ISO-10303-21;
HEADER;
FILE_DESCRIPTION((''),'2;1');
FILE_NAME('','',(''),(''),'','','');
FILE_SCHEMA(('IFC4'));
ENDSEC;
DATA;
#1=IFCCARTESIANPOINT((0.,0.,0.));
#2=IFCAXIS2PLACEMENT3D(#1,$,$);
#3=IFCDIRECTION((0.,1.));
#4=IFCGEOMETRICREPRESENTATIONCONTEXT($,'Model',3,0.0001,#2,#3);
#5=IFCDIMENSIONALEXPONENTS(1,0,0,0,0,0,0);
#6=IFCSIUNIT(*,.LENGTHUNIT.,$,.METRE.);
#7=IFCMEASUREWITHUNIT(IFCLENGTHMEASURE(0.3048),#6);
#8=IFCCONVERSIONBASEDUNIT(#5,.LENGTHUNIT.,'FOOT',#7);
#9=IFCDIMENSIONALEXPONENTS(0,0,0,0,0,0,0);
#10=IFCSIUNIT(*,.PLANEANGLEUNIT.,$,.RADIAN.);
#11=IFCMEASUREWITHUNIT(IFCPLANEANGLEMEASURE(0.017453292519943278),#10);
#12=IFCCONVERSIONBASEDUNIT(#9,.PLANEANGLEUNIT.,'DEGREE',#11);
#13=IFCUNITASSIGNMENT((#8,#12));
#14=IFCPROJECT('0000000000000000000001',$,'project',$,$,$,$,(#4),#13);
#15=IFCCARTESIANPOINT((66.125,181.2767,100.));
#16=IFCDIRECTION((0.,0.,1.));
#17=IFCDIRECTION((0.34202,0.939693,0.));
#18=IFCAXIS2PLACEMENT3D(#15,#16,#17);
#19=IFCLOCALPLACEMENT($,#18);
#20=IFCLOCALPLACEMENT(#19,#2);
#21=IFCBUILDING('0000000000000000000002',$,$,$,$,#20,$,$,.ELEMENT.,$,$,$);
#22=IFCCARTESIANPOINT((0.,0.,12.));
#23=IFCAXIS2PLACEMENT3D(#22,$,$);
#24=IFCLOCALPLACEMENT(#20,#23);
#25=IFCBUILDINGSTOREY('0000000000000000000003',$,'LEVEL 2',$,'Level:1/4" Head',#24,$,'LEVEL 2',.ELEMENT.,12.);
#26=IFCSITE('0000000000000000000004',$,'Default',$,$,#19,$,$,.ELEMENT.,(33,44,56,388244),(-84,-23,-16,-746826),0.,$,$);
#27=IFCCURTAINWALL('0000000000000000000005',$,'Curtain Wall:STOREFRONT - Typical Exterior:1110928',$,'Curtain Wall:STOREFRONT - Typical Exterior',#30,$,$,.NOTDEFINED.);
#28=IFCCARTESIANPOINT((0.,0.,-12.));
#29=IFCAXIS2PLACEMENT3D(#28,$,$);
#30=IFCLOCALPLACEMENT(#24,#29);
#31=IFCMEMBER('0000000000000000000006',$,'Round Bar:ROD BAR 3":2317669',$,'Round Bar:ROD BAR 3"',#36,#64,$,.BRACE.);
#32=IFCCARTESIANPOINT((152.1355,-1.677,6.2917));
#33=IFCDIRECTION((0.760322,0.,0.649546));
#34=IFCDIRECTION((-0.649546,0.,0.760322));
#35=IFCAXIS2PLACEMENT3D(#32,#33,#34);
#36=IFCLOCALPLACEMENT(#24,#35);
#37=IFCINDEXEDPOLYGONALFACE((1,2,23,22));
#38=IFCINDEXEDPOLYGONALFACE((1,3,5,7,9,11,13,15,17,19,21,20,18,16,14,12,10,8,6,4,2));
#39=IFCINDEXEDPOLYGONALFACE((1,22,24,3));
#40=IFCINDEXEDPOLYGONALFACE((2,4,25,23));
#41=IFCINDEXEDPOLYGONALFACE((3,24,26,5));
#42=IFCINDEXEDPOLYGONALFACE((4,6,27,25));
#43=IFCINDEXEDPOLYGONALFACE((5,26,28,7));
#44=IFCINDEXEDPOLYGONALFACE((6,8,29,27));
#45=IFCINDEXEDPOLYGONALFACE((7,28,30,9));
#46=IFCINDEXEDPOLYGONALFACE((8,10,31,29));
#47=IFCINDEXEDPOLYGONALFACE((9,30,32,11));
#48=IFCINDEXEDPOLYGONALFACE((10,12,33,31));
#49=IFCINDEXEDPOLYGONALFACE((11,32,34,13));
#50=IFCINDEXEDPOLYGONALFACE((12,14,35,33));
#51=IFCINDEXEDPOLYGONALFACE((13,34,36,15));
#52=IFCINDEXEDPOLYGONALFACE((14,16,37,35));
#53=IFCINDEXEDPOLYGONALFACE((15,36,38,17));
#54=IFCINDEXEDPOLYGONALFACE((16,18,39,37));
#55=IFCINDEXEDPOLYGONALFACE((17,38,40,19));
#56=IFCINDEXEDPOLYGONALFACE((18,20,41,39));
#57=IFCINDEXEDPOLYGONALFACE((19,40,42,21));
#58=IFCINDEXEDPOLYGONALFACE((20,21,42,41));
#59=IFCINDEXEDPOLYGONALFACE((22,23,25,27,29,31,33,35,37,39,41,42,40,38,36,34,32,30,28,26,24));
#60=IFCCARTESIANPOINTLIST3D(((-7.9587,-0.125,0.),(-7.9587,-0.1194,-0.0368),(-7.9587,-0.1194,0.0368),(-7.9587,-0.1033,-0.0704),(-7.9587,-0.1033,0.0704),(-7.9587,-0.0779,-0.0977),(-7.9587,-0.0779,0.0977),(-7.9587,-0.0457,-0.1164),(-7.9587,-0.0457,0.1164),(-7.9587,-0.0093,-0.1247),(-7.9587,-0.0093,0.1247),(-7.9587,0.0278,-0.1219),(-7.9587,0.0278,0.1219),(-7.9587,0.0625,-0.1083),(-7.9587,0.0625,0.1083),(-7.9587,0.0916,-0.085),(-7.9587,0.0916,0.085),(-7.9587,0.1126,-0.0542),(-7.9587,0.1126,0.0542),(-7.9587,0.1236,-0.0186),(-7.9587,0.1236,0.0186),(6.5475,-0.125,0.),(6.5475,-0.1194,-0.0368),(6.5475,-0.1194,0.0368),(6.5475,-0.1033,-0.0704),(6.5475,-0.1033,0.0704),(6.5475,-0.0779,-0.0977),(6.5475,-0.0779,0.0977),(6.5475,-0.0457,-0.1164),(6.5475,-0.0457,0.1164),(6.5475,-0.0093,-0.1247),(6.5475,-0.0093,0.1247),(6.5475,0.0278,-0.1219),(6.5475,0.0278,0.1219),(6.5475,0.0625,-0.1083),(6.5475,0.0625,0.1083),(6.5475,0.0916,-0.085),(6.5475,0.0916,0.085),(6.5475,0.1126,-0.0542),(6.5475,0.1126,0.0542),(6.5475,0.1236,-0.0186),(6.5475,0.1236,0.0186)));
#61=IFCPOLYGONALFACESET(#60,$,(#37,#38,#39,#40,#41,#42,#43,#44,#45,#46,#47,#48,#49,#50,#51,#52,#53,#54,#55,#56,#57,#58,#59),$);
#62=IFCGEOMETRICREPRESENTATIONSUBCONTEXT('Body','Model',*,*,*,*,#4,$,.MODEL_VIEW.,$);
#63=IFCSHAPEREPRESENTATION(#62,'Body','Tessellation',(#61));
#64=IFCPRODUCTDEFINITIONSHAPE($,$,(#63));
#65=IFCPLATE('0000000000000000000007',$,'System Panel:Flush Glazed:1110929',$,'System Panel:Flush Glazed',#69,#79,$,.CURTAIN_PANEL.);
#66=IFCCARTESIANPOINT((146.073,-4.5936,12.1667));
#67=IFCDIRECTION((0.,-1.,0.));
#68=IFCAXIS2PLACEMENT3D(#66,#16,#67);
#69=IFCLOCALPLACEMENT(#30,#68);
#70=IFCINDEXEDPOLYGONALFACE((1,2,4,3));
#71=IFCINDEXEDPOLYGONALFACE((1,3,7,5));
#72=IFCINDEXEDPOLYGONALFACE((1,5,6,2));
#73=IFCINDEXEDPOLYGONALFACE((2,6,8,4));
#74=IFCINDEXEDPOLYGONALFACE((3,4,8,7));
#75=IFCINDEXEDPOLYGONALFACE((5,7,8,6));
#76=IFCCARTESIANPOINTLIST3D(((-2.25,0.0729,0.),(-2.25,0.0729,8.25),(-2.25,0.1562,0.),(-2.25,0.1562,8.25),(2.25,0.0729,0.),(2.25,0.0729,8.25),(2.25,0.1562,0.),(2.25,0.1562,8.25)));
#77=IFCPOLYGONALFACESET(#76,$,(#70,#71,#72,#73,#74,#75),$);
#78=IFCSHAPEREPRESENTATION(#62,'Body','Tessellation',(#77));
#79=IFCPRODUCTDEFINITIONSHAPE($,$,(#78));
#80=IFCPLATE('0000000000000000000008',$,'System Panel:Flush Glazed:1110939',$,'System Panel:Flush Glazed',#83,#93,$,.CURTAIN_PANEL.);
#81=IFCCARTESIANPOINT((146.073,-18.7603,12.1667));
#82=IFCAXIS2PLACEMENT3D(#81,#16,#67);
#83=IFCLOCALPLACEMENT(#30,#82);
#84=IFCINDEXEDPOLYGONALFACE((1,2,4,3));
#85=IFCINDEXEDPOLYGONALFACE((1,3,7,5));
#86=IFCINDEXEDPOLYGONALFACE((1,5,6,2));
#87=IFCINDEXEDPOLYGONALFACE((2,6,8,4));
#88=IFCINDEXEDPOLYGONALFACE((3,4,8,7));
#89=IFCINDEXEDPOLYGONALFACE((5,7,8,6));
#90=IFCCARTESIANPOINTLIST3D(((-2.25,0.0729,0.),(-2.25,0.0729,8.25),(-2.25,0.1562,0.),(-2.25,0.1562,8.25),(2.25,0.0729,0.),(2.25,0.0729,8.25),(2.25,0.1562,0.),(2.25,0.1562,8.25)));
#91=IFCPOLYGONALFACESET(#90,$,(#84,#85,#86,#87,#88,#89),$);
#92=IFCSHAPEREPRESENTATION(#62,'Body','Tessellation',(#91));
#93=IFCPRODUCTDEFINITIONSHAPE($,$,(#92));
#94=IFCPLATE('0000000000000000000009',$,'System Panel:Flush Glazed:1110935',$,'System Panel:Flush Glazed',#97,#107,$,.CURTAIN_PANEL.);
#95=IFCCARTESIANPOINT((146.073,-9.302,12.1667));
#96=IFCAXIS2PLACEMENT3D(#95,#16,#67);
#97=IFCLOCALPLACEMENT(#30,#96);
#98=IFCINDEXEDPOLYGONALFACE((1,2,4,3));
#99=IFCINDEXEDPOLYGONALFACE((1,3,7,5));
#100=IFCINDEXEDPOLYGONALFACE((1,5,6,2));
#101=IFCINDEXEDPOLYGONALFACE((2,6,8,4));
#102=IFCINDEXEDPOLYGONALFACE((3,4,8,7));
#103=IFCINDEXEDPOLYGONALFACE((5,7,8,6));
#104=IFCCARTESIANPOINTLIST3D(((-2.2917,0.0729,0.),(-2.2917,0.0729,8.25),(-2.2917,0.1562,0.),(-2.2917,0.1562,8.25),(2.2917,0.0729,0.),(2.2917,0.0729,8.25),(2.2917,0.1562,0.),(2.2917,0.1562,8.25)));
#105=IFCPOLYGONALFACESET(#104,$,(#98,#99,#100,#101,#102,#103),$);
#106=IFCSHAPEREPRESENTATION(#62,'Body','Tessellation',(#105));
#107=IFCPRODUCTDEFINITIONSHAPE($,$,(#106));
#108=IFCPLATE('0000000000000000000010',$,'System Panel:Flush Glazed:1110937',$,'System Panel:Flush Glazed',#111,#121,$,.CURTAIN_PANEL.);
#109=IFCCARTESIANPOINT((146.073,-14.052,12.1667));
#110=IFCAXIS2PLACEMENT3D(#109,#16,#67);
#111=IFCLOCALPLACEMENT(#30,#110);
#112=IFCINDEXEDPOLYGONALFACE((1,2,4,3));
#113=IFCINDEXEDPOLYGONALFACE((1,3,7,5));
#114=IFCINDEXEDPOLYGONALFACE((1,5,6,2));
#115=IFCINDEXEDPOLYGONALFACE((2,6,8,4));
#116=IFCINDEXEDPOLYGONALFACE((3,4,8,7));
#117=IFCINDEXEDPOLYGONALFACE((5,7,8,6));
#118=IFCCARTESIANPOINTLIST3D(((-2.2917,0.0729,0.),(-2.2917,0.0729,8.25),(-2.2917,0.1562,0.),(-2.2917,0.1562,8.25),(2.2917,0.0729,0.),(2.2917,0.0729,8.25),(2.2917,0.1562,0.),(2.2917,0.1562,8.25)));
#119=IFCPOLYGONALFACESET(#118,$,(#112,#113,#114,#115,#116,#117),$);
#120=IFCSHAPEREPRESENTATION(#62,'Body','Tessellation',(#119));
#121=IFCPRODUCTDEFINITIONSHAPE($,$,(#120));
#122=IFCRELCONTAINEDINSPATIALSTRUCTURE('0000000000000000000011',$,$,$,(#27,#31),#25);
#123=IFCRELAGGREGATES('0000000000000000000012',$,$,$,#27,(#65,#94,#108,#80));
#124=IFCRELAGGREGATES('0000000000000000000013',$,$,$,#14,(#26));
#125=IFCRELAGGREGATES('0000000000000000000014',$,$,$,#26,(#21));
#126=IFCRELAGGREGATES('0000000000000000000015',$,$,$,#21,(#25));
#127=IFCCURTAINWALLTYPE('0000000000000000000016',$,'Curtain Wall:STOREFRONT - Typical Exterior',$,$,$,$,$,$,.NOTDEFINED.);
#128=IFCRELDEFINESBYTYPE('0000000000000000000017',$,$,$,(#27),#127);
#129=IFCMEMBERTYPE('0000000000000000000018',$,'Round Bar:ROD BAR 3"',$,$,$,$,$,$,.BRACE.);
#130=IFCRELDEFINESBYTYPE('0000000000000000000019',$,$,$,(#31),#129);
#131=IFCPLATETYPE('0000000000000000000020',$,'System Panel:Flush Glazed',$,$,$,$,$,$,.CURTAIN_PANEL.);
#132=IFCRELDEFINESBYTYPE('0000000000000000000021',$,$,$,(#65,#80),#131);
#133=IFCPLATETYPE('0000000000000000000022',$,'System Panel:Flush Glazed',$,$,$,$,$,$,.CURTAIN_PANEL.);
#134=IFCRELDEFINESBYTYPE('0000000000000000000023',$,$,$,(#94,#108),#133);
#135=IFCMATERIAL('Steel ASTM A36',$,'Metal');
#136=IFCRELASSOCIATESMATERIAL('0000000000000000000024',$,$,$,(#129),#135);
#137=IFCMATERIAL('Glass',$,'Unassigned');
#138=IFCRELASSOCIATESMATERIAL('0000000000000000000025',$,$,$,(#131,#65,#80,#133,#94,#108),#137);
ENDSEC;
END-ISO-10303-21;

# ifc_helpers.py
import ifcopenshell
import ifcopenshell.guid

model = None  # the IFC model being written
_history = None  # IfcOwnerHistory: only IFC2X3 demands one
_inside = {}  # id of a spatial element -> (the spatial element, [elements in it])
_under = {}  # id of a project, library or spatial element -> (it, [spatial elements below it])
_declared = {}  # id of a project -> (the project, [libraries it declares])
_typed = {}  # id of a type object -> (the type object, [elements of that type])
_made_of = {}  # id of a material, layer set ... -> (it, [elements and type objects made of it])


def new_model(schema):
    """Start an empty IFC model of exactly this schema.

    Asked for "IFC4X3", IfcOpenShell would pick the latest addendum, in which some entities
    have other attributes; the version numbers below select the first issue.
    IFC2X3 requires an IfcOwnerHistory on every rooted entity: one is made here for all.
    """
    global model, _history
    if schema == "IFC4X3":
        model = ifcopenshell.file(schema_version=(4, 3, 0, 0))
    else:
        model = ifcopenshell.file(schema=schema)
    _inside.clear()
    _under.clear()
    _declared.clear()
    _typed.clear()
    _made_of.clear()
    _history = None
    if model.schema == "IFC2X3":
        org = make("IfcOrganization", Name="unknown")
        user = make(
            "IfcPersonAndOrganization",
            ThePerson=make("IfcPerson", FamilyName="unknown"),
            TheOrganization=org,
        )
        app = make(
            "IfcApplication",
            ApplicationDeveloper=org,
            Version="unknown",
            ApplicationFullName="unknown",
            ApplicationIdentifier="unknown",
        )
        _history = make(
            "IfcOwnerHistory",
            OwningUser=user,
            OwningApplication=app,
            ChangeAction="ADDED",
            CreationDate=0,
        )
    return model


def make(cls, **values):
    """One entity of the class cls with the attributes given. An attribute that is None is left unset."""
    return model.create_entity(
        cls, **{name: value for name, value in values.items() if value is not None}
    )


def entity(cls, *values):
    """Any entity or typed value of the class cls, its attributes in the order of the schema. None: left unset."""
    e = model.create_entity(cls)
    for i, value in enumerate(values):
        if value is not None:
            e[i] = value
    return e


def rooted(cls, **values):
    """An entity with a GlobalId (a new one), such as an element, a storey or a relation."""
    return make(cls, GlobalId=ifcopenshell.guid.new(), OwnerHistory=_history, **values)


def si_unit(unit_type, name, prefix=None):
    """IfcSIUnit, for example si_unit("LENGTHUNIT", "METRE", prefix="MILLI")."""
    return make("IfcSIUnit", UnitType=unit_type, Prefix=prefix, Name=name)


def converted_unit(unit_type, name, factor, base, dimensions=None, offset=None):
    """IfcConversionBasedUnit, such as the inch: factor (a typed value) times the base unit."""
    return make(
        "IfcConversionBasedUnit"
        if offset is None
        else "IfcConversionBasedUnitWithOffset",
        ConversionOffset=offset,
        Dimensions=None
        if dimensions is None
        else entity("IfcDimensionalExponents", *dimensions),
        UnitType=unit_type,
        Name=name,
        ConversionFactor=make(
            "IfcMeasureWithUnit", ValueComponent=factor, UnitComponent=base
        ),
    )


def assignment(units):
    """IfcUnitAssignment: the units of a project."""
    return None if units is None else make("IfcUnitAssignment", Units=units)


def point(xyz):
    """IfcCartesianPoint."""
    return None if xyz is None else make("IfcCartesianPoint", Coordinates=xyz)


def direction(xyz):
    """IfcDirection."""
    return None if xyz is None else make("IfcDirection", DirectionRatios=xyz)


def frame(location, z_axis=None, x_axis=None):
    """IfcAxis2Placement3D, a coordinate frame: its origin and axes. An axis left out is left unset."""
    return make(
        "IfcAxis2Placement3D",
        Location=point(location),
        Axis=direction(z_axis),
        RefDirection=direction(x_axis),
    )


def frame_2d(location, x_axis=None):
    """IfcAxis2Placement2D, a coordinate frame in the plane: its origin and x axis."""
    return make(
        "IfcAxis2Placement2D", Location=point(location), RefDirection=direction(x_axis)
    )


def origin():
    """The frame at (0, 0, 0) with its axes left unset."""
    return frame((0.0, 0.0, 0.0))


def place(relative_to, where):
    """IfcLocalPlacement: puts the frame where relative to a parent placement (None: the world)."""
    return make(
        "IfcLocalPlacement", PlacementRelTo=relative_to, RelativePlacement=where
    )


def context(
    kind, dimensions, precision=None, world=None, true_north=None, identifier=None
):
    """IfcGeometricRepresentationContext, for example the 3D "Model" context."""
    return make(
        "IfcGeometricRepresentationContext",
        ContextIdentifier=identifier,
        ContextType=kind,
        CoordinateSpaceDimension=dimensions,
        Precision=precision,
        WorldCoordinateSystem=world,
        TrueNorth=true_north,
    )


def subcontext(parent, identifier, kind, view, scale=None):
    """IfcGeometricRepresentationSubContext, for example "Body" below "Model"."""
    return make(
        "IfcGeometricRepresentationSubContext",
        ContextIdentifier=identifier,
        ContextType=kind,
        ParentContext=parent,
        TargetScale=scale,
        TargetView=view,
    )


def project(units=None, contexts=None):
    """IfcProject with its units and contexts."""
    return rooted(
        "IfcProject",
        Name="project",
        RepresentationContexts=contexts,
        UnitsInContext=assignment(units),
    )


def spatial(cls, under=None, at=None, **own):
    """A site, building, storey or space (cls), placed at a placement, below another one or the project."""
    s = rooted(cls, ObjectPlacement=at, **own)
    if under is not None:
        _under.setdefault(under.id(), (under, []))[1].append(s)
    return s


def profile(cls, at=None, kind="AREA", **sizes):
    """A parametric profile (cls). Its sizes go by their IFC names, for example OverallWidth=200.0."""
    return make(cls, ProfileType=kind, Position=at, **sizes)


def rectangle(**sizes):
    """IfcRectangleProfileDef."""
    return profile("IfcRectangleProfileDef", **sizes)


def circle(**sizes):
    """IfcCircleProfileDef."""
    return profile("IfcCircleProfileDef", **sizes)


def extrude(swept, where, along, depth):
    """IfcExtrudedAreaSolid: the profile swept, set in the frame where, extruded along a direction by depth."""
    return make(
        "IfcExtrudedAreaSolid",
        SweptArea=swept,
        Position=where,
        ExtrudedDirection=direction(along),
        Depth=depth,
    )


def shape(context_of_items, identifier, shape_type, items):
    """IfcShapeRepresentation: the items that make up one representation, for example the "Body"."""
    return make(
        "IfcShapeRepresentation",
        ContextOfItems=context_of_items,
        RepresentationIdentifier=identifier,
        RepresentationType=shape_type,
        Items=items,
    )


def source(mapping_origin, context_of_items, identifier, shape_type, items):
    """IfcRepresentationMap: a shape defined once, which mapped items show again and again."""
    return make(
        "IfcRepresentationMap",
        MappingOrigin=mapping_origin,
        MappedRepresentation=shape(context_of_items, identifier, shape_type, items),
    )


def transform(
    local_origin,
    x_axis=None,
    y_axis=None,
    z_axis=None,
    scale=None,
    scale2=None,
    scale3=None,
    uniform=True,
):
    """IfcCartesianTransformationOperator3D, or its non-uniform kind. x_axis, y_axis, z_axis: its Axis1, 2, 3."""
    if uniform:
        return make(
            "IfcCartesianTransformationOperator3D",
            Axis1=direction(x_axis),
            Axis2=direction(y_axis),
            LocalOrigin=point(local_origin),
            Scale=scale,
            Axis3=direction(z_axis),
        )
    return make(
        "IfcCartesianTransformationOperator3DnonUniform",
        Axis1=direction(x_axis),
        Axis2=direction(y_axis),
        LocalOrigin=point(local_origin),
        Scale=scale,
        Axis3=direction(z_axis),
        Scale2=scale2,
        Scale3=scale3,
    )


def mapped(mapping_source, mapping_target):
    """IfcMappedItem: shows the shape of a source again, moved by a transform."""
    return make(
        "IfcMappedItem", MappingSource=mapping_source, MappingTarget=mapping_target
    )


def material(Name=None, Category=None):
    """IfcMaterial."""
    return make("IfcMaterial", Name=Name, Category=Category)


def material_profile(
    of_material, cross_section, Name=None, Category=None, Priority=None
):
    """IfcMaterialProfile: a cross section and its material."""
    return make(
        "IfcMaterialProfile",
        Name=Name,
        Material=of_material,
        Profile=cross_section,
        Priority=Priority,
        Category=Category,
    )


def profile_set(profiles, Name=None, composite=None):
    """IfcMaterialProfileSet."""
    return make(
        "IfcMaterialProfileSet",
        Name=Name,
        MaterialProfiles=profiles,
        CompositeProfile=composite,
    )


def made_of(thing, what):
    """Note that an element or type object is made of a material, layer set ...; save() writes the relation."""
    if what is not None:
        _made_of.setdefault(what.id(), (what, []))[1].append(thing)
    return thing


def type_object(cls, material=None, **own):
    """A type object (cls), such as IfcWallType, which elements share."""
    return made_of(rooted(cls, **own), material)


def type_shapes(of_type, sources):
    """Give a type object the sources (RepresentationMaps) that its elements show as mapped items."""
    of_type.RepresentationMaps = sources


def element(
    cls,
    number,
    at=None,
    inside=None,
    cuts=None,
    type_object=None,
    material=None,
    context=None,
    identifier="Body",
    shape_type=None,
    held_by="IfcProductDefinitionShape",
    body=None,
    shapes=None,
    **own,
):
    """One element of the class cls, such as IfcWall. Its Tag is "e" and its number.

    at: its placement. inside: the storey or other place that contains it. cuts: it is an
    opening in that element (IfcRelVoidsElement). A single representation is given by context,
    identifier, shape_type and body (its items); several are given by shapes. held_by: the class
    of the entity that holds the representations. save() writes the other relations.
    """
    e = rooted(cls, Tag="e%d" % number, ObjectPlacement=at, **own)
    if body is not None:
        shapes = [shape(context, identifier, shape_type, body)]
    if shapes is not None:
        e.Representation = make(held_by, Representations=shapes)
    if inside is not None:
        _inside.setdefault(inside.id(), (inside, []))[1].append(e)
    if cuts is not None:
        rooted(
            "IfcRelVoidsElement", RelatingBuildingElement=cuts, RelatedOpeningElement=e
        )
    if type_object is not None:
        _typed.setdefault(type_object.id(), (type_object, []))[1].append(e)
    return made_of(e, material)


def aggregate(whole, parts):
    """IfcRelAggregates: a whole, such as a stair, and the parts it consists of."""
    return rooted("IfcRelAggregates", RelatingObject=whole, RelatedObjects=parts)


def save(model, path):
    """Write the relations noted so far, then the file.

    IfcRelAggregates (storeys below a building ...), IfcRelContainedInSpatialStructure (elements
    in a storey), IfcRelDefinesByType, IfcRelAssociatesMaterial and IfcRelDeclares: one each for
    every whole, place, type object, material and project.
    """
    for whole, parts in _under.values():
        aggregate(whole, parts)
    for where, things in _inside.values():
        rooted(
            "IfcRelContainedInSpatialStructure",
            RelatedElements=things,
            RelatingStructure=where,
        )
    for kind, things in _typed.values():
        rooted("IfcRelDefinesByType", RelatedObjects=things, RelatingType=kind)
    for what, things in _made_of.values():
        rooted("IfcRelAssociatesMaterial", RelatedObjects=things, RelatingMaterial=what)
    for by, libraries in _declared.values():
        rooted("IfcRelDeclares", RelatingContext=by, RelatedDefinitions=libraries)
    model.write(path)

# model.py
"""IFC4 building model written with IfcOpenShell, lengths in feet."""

from ifc_helpers import new_model, entity, si_unit, converted_unit, direction, frame, frame_2d, origin, place, context, subcontext, project, spatial, rectangle, circle, extrude, source, transform, mapped, material, material_profile, profile_set, type_object, type_shapes, element, aggregate, save


model = new_model("IFC4")

# Units and contexts
model_context = context("Model", 3, precision=0.0001, world=origin(), true_north=direction((0.0, 1.0)))
body_context = subcontext(model_context, "Body", "Model", "MODEL_VIEW")
ifc_project = project(units=[converted_unit("LENGTHUNIT", "FOOT", entity("IfcLengthMeasure", 0.3048), si_unit("LENGTHUNIT", "METRE"), dimensions=[1, 0, 0, 0, 0, 0, 0]), converted_unit("PLANEANGLEUNIT", "DEGREE", entity("IfcPlaneAngleMeasure", 0.017453292519943278), si_unit("PLANEANGLEUNIT", "RADIAN"), dimensions=[0, 0, 0, 0, 0, 0, 0])], contexts=[model_context])

# Site, building, storey
site_placement = place(None, frame((66.125, 181.2767, 100.0), z_axis=(0.0, 0.0, 1.0), x_axis=(0.34202, 0.939693, 0.0)))
site = spatial("IfcSite", under=ifc_project, at=site_placement, Name="Default", CompositionType="ELEMENT", RefLatitude=(33, 44, 56, 388244), RefLongitude=(-84, -23, -16, -746826), RefElevation=0.0)
building_placement = place(site_placement, origin())
building = spatial("IfcBuilding", under=site, at=building_placement, CompositionType="ELEMENT")
storey_placement = place(building_placement, frame((0.0, 0.0, 12.0)))
storey = spatial("IfcBuildingStorey", under=building, at=storey_placement, Name="LEVEL 2", ObjectType="Level:1/4\" Head", LongName="LEVEL 2", CompositionType="ELEMENT", Elevation=12.0)

# Curtain wall
curtain_wall_type = type_object("IfcCurtainWallType", Name="Curtain Wall:STOREFRONT - Typical Exterior", PredefinedType="NOTDEFINED")
curtain_wall_1_placement = place(storey_placement, frame((0.0, 0.0, -12.0)))
curtain_wall_1 = element("IfcCurtainWall", 1, at=curtain_wall_1_placement, inside=storey, type_object=curtain_wall_type, Name="Curtain Wall:STOREFRONT - Typical Exterior:1110928", ObjectType="Curtain Wall:STOREFRONT - Typical Exterior", PredefinedType="NOTDEFINED")

# Member
ifc_material_1 = material(Name="Steel ASTM A36", Category="Metal")
ifc_material_profile_1 = material_profile(ifc_material_1, circle(Radius=0.125, at=frame_2d((0.0, 0.0), x_axis=(1.0, 0.0))), Name="ROD BAR 3\"")
ifc_profile_set_1 = profile_set([ifc_material_profile_1], Name="ROD BAR 3\"")
member_type_1 = type_object("IfcMemberType", Name="Round Bar:ROD BAR 3\"", PredefinedType="BRACE", material=ifc_profile_set_1)
shared_shape_1 = source(origin(), body_context, "Body", "SweptSolid", [
    extrude(circle(Radius=0.125, at=frame_2d((0.0, 0.0), x_axis=(1.0, 0.0))), frame((-7.9587, 0.0, 0.0), z_axis=(1.0, 0.0, 0.0), x_axis=(0.0, -1.0, 0.0)), (0.0, 0.0, 1.0), 14.5062),
])
type_shapes(member_type_1, [shared_shape_1])
member_1_placement = place(storey_placement, frame((152.1355, -1.677, 6.2917), z_axis=(0.760322, 0.0, 0.649546), x_axis=(-0.649546, 0.0, 0.760322)))
element("IfcMember", 2, at=member_1_placement, inside=storey, type_object=member_type_1, Name="Round Bar:ROD BAR 3\":2317669", ObjectType="Round Bar:ROD BAR 3\"", PredefinedType="BRACE", context=body_context, shape_type="MappedRepresentation", body=[
    mapped(shared_shape_1, transform((0.0, 0.0, 0.0), scale=1.0)),
])

# Plates
ifc_material_2 = material(Name="Glass", Category="Unassigned")
plate_type_1 = type_object("IfcPlateType", Name="System Panel:Flush Glazed", PredefinedType="CURTAIN_PANEL", material=ifc_material_2)
shared_shape_2 = source(origin(), body_context, "Body", "SweptSolid", [
    extrude(rectangle(XDim=0.0833, YDim=4.5, at=frame_2d((0.0, 0.0), x_axis=(1.0, 0.0))), frame((0.0, 0.1146, 0.0), z_axis=(0.0, 0.0, 1.0), x_axis=(0.0, 1.0, 0.0)), (0.0, 0.0, 1.0), 8.25),
])
type_shapes(plate_type_1, [shared_shape_2])
plate_1_placement = place(curtain_wall_1_placement, frame((146.073, -4.5936, 12.1667), z_axis=(0.0, 0.0, 1.0), x_axis=(0.0, -1.0, 0.0)))
plate_1 = element("IfcPlate", 3, at=plate_1_placement, type_object=plate_type_1, material=ifc_material_2, Name="System Panel:Flush Glazed:1110929", ObjectType="System Panel:Flush Glazed", PredefinedType="CURTAIN_PANEL", context=body_context, shape_type="MappedRepresentation", body=[
    mapped(shared_shape_2, transform((0.0, 0.0, 0.0), scale=1.0)),
])
plate_2_placement = place(curtain_wall_1_placement, frame((146.073, -18.7603, 12.1667), z_axis=(0.0, 0.0, 1.0), x_axis=(0.0, -1.0, 0.0)))
plate_2 = element("IfcPlate", 4, at=plate_2_placement, type_object=plate_type_1, material=ifc_material_2, Name="System Panel:Flush Glazed:1110939", ObjectType="System Panel:Flush Glazed", PredefinedType="CURTAIN_PANEL", context=body_context, shape_type="MappedRepresentation", body=[
    mapped(shared_shape_2, transform((0.0, 0.0, 0.0), scale=1.0)),
])
plate_type_2 = type_object("IfcPlateType", Name="System Panel:Flush Glazed", PredefinedType="CURTAIN_PANEL", material=ifc_material_2)
shared_shape_3 = source(origin(), body_context, "Body", "SweptSolid", [
    extrude(rectangle(XDim=0.0833, YDim=4.5833, at=frame_2d((0.0, 0.0), x_axis=(1.0, 0.0))), frame((0.0, 0.1146, 0.0), z_axis=(0.0, 0.0, 1.0), x_axis=(0.0, 1.0, 0.0)), (0.0, 0.0, 1.0), 8.25),
])
type_shapes(plate_type_2, [shared_shape_3])
plate_3_placement = place(curtain_wall_1_placement, frame((146.073, -9.302, 12.1667), z_axis=(0.0, 0.0, 1.0), x_axis=(0.0, -1.0, 0.0)))
plate_3 = element("IfcPlate", 5, at=plate_3_placement, type_object=plate_type_2, material=ifc_material_2, Name="System Panel:Flush Glazed:1110935", ObjectType="System Panel:Flush Glazed", PredefinedType="CURTAIN_PANEL", context=body_context, shape_type="MappedRepresentation", body=[
    mapped(shared_shape_3, transform((0.0, 0.0, 0.0), scale=1.0)),
])
plate_4_placement = place(curtain_wall_1_placement, frame((146.073, -14.052, 12.1667), z_axis=(0.0, 0.0, 1.0), x_axis=(0.0, -1.0, 0.0)))
plate_4 = element("IfcPlate", 6, at=plate_4_placement, type_object=plate_type_2, material=ifc_material_2, Name="System Panel:Flush Glazed:1110937", ObjectType="System Panel:Flush Glazed", PredefinedType="CURTAIN_PANEL", context=body_context, shape_type="MappedRepresentation", body=[
    mapped(shared_shape_3, transform((0.0, 0.0, 0.0), scale=1.0)),
])
aggregate(curtain_wall_1, [plate_1, plate_3, plate_4, plate_2])

save(model, "model.ifc")
